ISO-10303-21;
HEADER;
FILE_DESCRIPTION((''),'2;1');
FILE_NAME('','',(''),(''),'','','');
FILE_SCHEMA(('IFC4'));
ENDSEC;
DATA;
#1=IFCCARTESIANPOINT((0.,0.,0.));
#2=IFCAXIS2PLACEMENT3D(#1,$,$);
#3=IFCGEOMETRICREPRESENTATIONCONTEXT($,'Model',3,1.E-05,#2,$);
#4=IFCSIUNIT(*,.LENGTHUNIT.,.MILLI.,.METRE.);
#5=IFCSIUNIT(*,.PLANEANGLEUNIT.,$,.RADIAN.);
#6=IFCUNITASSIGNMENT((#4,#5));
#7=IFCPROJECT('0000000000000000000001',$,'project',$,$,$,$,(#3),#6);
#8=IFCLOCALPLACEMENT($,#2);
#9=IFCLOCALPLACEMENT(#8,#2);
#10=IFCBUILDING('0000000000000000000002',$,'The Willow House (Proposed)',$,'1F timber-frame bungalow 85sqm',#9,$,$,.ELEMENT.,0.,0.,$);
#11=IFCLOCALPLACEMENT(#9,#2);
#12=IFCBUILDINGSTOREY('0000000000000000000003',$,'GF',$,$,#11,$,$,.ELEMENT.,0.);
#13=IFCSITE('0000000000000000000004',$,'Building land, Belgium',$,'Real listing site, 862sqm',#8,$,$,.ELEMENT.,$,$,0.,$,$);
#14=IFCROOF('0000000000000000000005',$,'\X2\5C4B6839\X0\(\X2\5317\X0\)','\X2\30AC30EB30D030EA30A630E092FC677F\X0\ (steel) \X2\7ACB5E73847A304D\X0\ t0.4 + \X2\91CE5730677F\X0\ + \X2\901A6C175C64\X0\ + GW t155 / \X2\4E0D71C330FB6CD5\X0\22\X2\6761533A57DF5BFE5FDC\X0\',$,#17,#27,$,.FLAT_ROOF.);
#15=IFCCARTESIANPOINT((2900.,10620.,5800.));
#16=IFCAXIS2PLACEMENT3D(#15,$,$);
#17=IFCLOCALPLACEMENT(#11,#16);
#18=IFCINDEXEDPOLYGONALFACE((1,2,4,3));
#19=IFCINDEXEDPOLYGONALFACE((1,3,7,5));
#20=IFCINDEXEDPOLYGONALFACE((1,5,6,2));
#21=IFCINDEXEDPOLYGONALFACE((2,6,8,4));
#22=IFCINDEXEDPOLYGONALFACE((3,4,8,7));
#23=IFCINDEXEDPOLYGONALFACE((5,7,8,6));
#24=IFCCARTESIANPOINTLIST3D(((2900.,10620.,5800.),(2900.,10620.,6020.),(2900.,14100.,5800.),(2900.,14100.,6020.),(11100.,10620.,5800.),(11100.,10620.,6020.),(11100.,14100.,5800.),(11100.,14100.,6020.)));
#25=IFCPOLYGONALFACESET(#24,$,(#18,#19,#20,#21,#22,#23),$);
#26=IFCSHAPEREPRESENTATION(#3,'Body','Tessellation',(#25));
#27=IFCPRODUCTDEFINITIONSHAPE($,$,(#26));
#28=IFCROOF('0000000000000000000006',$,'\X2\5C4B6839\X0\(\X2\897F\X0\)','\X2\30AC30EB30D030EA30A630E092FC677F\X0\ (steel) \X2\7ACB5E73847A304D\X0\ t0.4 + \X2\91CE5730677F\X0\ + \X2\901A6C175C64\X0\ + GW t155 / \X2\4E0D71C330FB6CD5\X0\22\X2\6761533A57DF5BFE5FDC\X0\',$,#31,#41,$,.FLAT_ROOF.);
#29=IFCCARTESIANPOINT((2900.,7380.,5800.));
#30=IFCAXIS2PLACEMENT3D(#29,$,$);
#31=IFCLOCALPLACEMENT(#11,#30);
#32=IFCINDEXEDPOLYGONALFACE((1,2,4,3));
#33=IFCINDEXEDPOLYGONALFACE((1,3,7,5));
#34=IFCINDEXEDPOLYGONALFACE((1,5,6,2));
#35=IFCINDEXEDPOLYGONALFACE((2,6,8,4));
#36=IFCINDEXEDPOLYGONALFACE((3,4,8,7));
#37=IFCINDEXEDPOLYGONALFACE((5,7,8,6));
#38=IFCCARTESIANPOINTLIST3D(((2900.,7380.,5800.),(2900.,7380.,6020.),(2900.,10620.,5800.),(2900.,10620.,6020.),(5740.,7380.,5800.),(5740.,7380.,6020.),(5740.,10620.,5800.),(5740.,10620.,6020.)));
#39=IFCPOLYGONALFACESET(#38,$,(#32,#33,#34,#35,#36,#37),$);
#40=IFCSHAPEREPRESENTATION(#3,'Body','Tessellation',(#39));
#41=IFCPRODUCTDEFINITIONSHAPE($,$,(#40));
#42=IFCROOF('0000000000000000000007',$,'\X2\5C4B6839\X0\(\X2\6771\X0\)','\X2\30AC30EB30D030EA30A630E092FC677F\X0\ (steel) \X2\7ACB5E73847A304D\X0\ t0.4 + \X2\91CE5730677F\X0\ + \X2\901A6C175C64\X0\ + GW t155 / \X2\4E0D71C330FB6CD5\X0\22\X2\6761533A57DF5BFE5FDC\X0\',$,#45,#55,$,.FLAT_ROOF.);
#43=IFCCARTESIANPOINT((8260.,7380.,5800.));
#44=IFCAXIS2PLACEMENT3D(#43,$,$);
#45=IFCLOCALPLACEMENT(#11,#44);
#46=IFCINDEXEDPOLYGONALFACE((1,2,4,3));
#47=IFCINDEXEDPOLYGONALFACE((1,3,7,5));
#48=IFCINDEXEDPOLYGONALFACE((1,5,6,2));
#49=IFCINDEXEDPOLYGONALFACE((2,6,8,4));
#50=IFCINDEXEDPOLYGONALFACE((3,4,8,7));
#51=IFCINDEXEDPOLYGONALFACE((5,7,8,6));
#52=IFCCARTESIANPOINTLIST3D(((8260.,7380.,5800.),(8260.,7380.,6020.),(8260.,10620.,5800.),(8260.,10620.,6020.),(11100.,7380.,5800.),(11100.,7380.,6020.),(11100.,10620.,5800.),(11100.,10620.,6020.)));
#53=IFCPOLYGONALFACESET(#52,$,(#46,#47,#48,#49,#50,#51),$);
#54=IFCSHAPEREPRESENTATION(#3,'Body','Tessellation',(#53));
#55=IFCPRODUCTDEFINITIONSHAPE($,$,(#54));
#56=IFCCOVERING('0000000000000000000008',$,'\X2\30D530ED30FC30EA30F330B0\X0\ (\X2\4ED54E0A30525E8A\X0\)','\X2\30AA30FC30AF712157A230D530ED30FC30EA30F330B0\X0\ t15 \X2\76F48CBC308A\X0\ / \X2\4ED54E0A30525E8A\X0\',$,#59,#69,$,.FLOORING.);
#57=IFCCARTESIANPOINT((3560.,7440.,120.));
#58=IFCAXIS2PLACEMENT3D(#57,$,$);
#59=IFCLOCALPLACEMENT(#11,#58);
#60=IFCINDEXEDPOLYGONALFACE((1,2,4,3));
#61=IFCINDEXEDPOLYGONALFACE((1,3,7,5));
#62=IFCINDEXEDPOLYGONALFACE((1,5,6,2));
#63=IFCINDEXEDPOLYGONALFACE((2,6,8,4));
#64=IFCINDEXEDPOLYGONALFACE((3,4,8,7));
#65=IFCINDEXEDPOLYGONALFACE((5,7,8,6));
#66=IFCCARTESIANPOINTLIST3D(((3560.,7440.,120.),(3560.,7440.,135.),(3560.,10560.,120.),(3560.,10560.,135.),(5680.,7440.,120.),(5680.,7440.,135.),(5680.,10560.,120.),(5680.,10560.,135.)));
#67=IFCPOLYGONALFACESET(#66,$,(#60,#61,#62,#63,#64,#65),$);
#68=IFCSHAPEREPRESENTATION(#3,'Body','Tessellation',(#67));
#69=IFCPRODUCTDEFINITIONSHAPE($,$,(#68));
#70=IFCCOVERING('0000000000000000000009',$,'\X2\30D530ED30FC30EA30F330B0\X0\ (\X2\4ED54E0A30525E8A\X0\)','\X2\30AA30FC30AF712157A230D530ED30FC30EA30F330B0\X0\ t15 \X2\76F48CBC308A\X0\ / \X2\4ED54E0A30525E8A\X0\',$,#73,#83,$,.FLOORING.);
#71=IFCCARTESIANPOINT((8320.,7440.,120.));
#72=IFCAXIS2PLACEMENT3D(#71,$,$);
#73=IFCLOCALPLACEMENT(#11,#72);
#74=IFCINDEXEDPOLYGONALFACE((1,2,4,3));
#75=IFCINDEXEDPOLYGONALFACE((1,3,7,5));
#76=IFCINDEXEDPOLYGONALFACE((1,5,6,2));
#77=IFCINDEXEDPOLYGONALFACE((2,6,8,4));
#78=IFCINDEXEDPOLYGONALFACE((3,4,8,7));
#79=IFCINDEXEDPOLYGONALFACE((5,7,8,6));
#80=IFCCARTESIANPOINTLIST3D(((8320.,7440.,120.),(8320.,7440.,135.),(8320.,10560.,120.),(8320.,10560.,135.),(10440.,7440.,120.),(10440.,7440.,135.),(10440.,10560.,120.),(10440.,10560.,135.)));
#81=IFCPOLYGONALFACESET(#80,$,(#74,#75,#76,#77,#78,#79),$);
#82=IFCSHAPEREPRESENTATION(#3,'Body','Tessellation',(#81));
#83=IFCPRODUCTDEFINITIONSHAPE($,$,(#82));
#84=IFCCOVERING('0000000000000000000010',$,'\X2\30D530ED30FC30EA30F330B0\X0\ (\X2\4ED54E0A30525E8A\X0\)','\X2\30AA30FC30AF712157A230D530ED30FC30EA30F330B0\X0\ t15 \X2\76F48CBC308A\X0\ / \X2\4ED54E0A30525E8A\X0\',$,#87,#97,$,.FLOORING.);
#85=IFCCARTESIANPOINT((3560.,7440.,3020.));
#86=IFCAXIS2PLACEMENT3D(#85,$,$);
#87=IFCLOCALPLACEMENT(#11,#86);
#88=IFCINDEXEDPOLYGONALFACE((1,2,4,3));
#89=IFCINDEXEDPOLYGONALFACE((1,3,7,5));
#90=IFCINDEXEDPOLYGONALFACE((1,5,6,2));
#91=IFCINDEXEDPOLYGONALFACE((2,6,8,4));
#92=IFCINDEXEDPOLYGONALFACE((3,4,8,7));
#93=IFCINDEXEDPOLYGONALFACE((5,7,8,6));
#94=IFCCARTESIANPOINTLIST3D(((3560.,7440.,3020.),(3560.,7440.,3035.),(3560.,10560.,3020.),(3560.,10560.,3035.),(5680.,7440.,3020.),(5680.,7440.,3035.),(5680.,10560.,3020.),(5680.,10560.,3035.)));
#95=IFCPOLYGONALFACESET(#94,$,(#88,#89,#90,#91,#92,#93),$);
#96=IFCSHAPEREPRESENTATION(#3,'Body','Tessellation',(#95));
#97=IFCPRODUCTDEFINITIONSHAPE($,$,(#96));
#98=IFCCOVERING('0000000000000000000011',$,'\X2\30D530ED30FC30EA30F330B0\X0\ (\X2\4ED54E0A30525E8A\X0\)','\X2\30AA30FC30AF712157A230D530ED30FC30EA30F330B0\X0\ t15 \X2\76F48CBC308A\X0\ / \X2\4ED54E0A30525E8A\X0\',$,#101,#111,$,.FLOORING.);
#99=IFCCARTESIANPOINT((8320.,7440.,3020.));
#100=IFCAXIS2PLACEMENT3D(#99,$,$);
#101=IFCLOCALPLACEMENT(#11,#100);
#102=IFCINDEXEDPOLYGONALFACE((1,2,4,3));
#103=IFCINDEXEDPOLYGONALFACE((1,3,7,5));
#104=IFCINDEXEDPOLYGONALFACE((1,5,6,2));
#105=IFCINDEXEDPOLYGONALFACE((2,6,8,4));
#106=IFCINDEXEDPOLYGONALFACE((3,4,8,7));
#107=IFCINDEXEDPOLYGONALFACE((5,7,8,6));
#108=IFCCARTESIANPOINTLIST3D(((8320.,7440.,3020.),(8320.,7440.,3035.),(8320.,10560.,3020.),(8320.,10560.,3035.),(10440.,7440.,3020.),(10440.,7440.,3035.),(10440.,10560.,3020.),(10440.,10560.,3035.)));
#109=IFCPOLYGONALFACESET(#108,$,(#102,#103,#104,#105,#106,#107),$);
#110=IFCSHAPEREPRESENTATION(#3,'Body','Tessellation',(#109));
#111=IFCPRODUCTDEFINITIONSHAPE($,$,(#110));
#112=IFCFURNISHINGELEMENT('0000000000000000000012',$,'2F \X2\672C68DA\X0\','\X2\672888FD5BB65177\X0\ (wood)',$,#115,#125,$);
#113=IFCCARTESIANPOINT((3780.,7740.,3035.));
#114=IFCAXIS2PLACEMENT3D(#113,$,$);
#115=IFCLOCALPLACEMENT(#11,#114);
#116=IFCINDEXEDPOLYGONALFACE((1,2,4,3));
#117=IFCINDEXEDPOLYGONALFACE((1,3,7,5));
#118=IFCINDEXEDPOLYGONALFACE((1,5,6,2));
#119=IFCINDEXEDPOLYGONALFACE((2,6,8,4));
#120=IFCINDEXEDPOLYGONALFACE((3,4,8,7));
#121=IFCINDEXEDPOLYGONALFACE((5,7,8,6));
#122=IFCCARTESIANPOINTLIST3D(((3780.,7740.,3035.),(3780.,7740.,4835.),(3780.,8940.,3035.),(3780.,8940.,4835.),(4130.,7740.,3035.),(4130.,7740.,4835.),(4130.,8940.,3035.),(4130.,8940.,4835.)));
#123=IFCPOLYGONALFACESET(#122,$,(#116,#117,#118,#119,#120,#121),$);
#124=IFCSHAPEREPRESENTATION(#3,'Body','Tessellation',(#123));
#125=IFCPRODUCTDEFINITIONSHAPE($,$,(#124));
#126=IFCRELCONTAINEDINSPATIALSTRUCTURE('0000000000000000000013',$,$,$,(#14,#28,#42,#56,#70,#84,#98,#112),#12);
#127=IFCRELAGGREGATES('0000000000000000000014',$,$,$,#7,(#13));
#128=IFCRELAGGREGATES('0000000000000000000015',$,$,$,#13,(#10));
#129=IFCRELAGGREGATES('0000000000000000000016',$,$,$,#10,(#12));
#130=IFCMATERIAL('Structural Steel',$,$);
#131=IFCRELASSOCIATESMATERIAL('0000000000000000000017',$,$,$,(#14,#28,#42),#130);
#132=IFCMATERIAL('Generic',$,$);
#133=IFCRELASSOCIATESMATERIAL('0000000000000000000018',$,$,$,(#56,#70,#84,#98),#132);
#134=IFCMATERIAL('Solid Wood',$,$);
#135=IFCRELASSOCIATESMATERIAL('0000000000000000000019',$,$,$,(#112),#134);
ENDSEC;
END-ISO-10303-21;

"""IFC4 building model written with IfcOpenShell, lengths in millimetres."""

from ifc_helpers import new_model, si_unit, frame, frame_2d, origin, place, context, project, spatial, rectangle, extrude, material, element, save


model = new_model("IFC4")

# Units and contexts
model_context = context("Model", 3, precision=1e-05, world=origin())
ifc_project = project(units=[si_unit("LENGTHUNIT", "METRE", prefix="MILLI"), si_unit("PLANEANGLEUNIT", "RADIAN")], contexts=[model_context])

# Site, building, storey
site_placement = place(None, origin())
site = spatial("IfcSite", under=ifc_project, at=site_placement, Name="Building land, Belgium", ObjectType="Real listing site, 862sqm", CompositionType="ELEMENT", RefElevation=0.0)
building_placement = place(site_placement, origin())
building = spatial("IfcBuilding", under=site, at=building_placement, Name="The Willow House (Proposed)", ObjectType="1F timber-frame bungalow 85sqm", CompositionType="ELEMENT", ElevationOfRefHeight=0.0, ElevationOfTerrain=0.0)
storey_placement = place(building_placement, origin())
storey = spatial("IfcBuildingStorey", under=building, at=storey_placement, Name="GF", CompositionType="ELEMENT", Elevation=0.0)

# Shared definitions
ifc_material_1 = material(Name="Solid Wood")

# Shared definitions
ifc_material_2 = material(Name="Generic")

# Roofs
ifc_material_3 = material(Name="Structural Steel")
roof_1_placement = place(storey_placement, frame((2900.0, 10620.0, 5800.0)))
element("IfcRoof", 1, at=roof_1_placement, inside=storey, material=ifc_material_3, Name="屋根(北)", Description="ガルバリウム鋼板 (steel) 立平葺き t0.4 + 野地板 + 通気層 + GW t155 / 不燃・法22条区域対応", PredefinedType="FLAT_ROOF", context=model_context, shape_type="SweptSolid", body=[
    extrude(rectangle(XDim=8200.0, YDim=3480.0, at=frame_2d((4100.0, 1740.0))), frame((2900.0, 10620.0, 5800.0)), (0.0, 0.0, 1.0), 220.0),
])
roof_2_placement = place(storey_placement, frame((2900.0, 7380.0, 5800.0)))
element("IfcRoof", 2, at=roof_2_placement, inside=storey, material=ifc_material_3, Name="屋根(西)", Description="ガルバリウム鋼板 (steel) 立平葺き t0.4 + 野地板 + 通気層 + GW t155 / 不燃・法22条区域対応", PredefinedType="FLAT_ROOF", context=model_context, shape_type="SweptSolid", body=[
    extrude(rectangle(XDim=2840.0, YDim=3240.0, at=frame_2d((1420.0, 1620.0))), frame((2900.0, 7380.0, 5800.0)), (0.0, 0.0, 1.0), 220.0),
])
roof_3_placement = place(storey_placement, frame((8260.0, 7380.0, 5800.0)))
element("IfcRoof", 3, at=roof_3_placement, inside=storey, material=ifc_material_3, Name="屋根(東)", Description="ガルバリウム鋼板 (steel) 立平葺き t0.4 + 野地板 + 通気層 + GW t155 / 不燃・法22条区域対応", PredefinedType="FLAT_ROOF", context=model_context, shape_type="SweptSolid", body=[
    extrude(rectangle(XDim=2840.0, YDim=3240.0, at=frame_2d((1420.0, 1620.0))), frame((8260.0, 7380.0, 5800.0)), (0.0, 0.0, 1.0), 220.0),
])

# Coverings
covering_1_placement = place(storey_placement, frame((3560.0, 7440.0, 120.0)))
element("IfcCovering", 4, at=covering_1_placement, inside=storey, material=ifc_material_2, Name="フローリング (仕上げ床)", Description="オーク無垢フローリング t15 直貼り / 仕上げ床", PredefinedType="FLOORING", context=model_context, shape_type="SweptSolid", body=[
    extrude(rectangle(XDim=2120.0, YDim=3120.0, at=frame_2d((1060.0, 1560.0))), frame((3560.0, 7440.0, 120.0)), (0.0, 0.0, 1.0), 15.0),
])
covering_2_placement = place(storey_placement, frame((8320.0, 7440.0, 120.0)))
element("IfcCovering", 5, at=covering_2_placement, inside=storey, material=ifc_material_2, Name="フローリング (仕上げ床)", Description="オーク無垢フローリング t15 直貼り / 仕上げ床", PredefinedType="FLOORING", context=model_context, shape_type="SweptSolid", body=[
    extrude(rectangle(XDim=2120.0, YDim=3120.0, at=frame_2d((1060.0, 1560.0))), frame((8320.0, 7440.0, 120.0)), (0.0, 0.0, 1.0), 15.0),
])
covering_3_placement = place(storey_placement, frame((3560.0, 7440.0, 3020.0)))
element("IfcCovering", 6, at=covering_3_placement, inside=storey, material=ifc_material_2, Name="フローリング (仕上げ床)", Description="オーク無垢フローリング t15 直貼り / 仕上げ床", PredefinedType="FLOORING", context=model_context, shape_type="SweptSolid", body=[
    extrude(rectangle(XDim=2120.0, YDim=3120.0, at=frame_2d((1060.0, 1560.0))), frame((3560.0, 7440.0, 3020.0)), (0.0, 0.0, 1.0), 15.0),
])
covering_4_placement = place(storey_placement, frame((8320.0, 7440.0, 3020.0)))
element("IfcCovering", 7, at=covering_4_placement, inside=storey, material=ifc_material_2, Name="フローリング (仕上げ床)", Description="オーク無垢フローリング t15 直貼り / 仕上げ床", PredefinedType="FLOORING", context=model_context, shape_type="SweptSolid", body=[
    extrude(rectangle(XDim=2120.0, YDim=3120.0, at=frame_2d((1060.0, 1560.0))), frame((8320.0, 7440.0, 3020.0)), (0.0, 0.0, 1.0), 15.0),
])

# Furnishing element
furnishing_placement = place(storey_placement, frame((3780.0, 7740.0, 3035.0)))
element("IfcFurnishingElement", 8, at=furnishing_placement, inside=storey, material=ifc_material_1, Name="2F 本棚", Description="木製家具 (wood)", context=model_context, shape_type="SweptSolid", body=[
    extrude(rectangle(XDim=350.0, YDim=1200.0, at=frame_2d((175.0, 600.0))), frame((3780.0, 7740.0, 3035.0)), (0.0, 0.0, 1.0), 1800.0),
])

save(model, "model.ifc")
